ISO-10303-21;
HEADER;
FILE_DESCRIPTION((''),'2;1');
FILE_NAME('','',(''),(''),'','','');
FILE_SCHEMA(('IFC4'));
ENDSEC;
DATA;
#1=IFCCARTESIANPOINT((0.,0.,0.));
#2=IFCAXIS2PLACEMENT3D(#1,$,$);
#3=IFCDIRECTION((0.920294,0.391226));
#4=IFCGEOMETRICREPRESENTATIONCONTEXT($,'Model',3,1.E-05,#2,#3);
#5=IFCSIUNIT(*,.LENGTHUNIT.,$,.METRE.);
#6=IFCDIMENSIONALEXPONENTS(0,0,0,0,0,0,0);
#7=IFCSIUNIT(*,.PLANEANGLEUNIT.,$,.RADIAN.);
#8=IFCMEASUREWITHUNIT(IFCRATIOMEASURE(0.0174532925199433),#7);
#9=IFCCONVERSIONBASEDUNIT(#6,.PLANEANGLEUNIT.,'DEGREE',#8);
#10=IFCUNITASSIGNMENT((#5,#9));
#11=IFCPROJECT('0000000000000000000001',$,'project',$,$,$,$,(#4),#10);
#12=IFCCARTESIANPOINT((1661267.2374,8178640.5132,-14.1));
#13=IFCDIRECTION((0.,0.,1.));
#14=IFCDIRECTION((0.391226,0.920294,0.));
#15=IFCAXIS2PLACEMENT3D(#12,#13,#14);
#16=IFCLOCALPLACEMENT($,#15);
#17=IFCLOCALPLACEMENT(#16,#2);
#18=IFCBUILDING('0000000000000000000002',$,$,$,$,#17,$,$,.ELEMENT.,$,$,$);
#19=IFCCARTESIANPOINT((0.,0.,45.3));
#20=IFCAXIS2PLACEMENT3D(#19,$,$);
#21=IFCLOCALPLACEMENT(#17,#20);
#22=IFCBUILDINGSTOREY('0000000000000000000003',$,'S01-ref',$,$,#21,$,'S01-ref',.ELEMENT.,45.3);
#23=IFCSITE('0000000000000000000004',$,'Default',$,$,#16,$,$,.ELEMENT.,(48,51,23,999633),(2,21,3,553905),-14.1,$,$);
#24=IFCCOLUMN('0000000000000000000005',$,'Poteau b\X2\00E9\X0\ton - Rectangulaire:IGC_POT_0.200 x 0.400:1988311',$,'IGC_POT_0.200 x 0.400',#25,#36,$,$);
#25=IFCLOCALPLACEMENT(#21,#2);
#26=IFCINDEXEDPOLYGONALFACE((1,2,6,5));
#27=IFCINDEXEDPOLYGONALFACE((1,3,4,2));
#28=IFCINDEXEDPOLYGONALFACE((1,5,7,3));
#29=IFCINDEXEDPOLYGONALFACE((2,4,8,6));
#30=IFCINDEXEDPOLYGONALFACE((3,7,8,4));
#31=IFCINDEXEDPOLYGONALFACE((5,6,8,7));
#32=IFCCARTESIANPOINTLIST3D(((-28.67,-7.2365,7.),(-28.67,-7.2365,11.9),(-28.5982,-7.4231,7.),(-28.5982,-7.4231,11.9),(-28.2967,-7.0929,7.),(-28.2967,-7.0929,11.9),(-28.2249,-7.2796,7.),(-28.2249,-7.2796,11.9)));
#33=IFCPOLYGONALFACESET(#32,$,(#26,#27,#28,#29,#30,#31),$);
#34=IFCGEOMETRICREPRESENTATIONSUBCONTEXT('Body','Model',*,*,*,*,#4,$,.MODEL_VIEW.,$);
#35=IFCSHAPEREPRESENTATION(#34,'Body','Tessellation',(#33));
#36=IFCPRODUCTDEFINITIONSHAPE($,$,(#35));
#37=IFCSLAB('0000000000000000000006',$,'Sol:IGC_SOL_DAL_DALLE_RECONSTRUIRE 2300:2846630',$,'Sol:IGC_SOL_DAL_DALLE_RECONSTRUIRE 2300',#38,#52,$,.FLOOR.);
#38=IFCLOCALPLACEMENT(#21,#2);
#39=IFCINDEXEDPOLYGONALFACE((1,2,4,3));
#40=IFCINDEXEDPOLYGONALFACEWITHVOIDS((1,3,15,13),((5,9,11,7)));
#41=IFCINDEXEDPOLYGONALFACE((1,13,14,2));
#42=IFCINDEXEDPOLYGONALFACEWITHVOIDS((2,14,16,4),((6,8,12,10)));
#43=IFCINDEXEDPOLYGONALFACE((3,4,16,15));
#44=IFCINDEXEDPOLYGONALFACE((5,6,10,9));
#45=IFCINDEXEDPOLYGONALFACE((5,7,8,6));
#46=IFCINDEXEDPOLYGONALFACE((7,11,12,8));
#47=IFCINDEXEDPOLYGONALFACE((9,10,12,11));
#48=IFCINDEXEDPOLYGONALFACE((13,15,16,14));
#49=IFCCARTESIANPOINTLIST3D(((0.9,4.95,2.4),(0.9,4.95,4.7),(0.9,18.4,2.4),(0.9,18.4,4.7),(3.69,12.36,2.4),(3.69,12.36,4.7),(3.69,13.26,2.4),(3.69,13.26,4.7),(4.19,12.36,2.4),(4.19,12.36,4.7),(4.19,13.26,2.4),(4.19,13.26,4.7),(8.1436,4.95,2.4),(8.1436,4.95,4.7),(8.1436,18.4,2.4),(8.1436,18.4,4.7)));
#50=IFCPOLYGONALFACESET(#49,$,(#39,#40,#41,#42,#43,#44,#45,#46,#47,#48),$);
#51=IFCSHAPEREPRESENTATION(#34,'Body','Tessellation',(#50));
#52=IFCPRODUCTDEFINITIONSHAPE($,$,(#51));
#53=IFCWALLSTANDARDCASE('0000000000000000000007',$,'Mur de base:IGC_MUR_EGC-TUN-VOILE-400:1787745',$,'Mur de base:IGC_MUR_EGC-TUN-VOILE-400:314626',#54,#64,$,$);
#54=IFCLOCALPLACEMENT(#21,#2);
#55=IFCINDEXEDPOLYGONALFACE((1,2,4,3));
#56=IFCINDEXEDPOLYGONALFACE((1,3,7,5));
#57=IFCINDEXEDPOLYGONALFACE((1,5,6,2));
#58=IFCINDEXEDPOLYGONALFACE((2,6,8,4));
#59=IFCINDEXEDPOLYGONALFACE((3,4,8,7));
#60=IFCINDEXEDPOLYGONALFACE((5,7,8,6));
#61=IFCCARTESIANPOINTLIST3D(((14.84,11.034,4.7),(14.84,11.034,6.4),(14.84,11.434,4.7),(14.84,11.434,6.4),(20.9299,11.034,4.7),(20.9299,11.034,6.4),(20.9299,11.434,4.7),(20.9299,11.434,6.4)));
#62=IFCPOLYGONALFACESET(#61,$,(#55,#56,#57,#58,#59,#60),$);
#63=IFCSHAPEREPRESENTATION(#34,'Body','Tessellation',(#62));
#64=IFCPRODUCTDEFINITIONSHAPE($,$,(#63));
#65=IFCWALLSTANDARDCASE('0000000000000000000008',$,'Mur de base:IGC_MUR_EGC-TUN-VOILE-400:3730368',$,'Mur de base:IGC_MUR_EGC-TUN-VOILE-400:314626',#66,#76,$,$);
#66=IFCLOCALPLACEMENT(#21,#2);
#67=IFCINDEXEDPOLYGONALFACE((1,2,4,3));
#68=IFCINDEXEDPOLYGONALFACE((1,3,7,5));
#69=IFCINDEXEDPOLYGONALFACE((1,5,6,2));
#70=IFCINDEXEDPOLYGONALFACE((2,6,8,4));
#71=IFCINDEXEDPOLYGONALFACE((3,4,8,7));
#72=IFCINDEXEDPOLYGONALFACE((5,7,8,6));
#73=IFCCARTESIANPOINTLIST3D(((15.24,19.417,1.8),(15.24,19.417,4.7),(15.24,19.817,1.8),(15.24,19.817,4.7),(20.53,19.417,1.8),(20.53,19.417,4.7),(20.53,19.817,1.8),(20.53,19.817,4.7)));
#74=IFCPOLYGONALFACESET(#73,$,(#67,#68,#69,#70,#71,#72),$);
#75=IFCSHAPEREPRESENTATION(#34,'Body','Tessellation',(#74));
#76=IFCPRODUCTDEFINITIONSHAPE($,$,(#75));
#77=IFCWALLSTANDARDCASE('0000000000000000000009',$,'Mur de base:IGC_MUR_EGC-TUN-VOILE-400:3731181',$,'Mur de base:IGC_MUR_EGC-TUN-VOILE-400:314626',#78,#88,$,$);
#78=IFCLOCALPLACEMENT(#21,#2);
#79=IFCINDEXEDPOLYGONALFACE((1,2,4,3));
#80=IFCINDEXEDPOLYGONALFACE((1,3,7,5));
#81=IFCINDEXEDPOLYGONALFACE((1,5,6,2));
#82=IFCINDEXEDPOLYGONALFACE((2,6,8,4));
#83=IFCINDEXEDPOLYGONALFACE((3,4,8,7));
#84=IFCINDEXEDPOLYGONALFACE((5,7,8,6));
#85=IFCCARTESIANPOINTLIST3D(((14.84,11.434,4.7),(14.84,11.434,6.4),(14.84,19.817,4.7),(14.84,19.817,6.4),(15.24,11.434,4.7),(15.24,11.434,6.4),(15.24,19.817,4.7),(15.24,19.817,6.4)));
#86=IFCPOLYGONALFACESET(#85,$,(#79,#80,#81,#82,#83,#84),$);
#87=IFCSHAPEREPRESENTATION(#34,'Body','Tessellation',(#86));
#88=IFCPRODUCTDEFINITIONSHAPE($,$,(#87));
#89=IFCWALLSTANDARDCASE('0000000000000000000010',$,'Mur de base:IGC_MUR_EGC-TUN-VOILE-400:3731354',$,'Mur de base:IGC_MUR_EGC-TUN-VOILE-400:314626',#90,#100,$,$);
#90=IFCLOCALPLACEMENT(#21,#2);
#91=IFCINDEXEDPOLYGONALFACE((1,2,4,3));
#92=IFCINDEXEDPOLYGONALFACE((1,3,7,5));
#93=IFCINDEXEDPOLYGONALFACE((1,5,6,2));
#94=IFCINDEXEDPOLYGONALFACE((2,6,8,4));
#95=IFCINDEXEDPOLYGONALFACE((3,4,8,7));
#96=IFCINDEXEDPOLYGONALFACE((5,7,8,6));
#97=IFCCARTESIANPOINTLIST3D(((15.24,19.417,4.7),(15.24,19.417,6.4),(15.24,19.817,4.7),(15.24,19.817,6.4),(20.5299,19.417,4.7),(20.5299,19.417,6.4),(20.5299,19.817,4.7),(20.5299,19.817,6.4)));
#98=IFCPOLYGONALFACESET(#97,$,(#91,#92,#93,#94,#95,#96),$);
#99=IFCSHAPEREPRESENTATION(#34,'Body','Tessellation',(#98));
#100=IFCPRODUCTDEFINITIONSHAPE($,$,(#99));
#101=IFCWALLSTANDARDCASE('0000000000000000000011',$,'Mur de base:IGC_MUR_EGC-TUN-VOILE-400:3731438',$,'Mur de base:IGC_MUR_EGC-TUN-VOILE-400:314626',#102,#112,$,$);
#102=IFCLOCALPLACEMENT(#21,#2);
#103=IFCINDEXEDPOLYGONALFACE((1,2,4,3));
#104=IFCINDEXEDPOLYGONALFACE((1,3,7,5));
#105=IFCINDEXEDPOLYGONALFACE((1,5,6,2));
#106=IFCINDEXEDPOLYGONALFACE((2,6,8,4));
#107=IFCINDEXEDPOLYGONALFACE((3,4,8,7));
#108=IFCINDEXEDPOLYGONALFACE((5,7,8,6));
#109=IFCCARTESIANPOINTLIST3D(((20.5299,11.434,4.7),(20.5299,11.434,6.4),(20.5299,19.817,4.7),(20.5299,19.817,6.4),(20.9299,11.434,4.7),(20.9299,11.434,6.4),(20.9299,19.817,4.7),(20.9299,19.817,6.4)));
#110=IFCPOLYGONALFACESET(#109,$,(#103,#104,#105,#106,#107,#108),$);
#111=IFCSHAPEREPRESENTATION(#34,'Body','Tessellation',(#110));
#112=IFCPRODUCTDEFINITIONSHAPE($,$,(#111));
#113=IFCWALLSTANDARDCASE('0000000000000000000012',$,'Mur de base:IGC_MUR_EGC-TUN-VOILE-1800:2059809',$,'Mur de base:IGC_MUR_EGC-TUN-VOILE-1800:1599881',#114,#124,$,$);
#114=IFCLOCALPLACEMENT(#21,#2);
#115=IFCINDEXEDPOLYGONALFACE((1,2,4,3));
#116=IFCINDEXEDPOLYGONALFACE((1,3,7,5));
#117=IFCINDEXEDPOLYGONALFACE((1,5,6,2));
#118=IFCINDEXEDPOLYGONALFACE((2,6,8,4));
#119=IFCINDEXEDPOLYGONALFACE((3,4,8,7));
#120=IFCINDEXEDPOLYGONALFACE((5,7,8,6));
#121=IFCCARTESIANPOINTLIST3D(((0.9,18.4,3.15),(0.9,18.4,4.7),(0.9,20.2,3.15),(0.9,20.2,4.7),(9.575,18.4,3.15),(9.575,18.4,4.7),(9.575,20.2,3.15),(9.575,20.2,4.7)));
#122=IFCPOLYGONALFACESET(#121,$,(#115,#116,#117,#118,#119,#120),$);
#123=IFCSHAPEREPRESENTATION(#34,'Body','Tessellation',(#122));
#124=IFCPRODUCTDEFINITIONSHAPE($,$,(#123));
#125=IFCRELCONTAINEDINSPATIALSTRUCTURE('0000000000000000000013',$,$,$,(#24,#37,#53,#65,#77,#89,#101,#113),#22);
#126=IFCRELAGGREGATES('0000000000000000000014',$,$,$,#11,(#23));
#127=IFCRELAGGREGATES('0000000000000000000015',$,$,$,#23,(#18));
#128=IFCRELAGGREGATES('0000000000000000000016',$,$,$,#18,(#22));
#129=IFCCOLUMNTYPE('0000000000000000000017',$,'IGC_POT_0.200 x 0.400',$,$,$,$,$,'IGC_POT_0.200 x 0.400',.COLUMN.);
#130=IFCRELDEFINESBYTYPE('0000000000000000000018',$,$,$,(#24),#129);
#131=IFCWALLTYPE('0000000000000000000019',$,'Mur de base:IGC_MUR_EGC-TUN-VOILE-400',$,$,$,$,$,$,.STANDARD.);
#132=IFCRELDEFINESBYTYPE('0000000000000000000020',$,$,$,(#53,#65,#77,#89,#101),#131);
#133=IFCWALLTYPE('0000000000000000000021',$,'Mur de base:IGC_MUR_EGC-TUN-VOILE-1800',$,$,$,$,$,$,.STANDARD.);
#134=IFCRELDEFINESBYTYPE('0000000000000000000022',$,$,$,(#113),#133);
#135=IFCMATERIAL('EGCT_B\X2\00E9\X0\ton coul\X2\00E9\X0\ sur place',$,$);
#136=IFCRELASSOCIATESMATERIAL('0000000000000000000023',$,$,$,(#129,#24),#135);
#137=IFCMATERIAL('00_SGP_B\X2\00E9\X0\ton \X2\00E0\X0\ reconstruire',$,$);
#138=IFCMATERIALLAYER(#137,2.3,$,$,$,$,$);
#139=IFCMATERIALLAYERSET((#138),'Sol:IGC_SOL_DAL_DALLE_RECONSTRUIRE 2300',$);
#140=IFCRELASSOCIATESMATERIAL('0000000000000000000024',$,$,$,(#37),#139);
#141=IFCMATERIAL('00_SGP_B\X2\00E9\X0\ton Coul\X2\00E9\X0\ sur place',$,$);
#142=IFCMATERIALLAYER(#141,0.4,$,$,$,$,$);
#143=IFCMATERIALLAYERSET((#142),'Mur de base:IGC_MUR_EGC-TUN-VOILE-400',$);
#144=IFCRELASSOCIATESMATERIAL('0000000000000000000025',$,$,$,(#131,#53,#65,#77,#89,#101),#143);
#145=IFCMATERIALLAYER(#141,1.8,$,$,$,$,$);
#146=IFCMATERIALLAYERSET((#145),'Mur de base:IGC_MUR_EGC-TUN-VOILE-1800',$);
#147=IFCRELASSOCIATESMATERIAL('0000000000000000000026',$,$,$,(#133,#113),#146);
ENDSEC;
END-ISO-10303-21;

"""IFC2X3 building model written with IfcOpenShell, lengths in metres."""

from ifc_helpers import new_model, entity, si_unit, converted_unit, direction, frame, frame_2d, origin, origin_2d_with_axis, place, context, subcontext, project, spatial, rectangle, extrude, source, transform, mapped, material, layer, layer_set, layer_usage, type_object, type_shapes, element, save


model = new_model("IFC2X3")

# Units and contexts
model_context = context("Model", 3, precision=1e-05, world=origin(), true_north=direction((0.920294, 0.391226)))
body_context = subcontext(model_context, "Body", "Model", "MODEL_VIEW")
ifc_project = project(units=[si_unit("LENGTHUNIT", "METRE"), converted_unit("PLANEANGLEUNIT", "DEGREE", entity("IfcRatioMeasure", 0.0174532925199433), si_unit("PLANEANGLEUNIT", "RADIAN"), dimensions=[0, 0, 0, 0, 0, 0, 0])], contexts=[model_context])

# Site, building, storey
site_placement = place(None, frame((1661267.2374, 8178640.5132, -14.1), z_axis=(0.0, 0.0, 1.0), x_axis=(0.391226, 0.920294, 0.0)))
site = spatial("IfcSite", under=ifc_project, at=site_placement, Name="Default", CompositionType="ELEMENT", RefLatitude=(48, 51, 23, 999633), RefLongitude=(2, 21, 3, 553905), RefElevation=-14.1)
building_placement = place(site_placement, origin())
building = spatial("IfcBuilding", under=site, at=building_placement, CompositionType="ELEMENT")
storey_placement = place(building_placement, frame((0.0, 0.0, 45.3)))
storey = spatial("IfcBuildingStorey", under=building, at=storey_placement, Name="S01-ref", LongName="S01-ref", CompositionType="ELEMENT", Elevation=45.3)

# Column
ifc_material_1 = material(Name="EGCT_Béton coulé sur place")
column_type = type_object("IfcColumnType", Name="IGC_POT_0.200 x 0.400", ElementType="IGC_POT_0.200 x 0.400", PredefinedType="COLUMN", material=ifc_material_1)
shared_shape = source(origin(), body_context, "Body", "SweptSolid", [
    extrude(rectangle(XDim=0.2, YDim=0.4, at=frame_2d((0.0, 0.0), x_axis=(1.0, 0.0))), frame((-28.4474, -7.258, 52.3), z_axis=(0.0, 0.0, 1.0), x_axis=(-0.358954, 0.933355, 0.0)), (0.0, 0.0, 1.0), 4.9),
])
type_shapes(column_type, [shared_shape])
column_placement = place(storey_placement, frame((0.0, 0.0, -45.3)))
element("IfcColumn", 1, at=column_placement, inside=storey, type_object=column_type, material=ifc_material_1, Name="Poteau béton - Rectangulaire:IGC_POT_0.200 x 0.400:1988311", ObjectType="IGC_POT_0.200 x 0.400", context=body_context, shape_type="MappedRepresentation", body=[
    mapped(shared_shape, transform((0.0, 0.0, 0.0), scale=1.0)),
])

# Slab, opening
ifc_material_2 = material(Name="00_SGP_Béton à reconstruire")
ifc_layer_1 = layer(ifc_material_2, 2.3)
ifc_layer_set_1 = layer_set([ifc_layer_1], Name="Sol:IGC_SOL_DAL_DALLE_RECONSTRUIRE 2300")
ifc_layer_usage_1 = layer_usage(ifc_layer_set_1, "AXIS3", "POSITIVE", 0.0)
slab_placement = place(storey_placement, frame((0.9, 4.95, 2.4)))
slab = element("IfcSlab", 2, at=slab_placement, inside=storey, material=ifc_layer_usage_1, Name="Sol:IGC_SOL_DAL_DALLE_RECONSTRUIRE 2300:2846630", ObjectType="Sol:IGC_SOL_DAL_DALLE_RECONSTRUIRE 2300", PredefinedType="FLOOR", context=body_context, shape_type="SweptSolid", body=[
    extrude(rectangle(XDim=13.45, YDim=7.2436, at=frame_2d((0.0, 0.0), x_axis=(0.0, -1.0))), frame((3.6218, 6.725, 2.3), z_axis=(0.0, 0.0, -1.0), x_axis=(-1.0, 0.0, 0.0)), (0.0, 0.0, 1.0), 2.3),
])
opening_1_placement = place(slab_placement, origin())
element("IfcOpeningElement", 3, at=opening_1_placement, cuts=slab, ObjectType="Opening", context=body_context, shape_type="SweptSolid", body=[
    extrude(rectangle(XDim=0.5, YDim=0.9, at=origin_2d_with_axis()), frame((3.04, 7.86, 0.0), z_axis=(0.0, 0.0, 1.0), x_axis=(-1.0, 0.0, 0.0)), (0.0, 0.0, 1.0), 2.3),
])

# Shared definitions
ifc_material_3 = material(Name="00_SGP_Béton Coulé sur place")
ifc_layer_2 = layer(ifc_material_3, 0.4)
ifc_layer_set_2 = layer_set([ifc_layer_2], Name="Mur de base:IGC_MUR_EGC-TUN-VOILE-400")
wall_type_1 = type_object("IfcWallType", Name="Mur de base:IGC_MUR_EGC-TUN-VOILE-400", PredefinedType="STANDARD", material=ifc_layer_set_2)

# Walls
ifc_layer_usage_2 = layer_usage(ifc_layer_set_2, "AXIS2", "NEGATIVE", 0.2)
wall_1_placement = place(storey_placement, frame((20.9299, 11.234, 4.7), z_axis=(0.0, 0.0, 1.0), x_axis=(-1.0, 0.0, 0.0)))
element("IfcWallStandardCase", 4, at=wall_1_placement, inside=storey, type_object=wall_type_1, material=ifc_layer_usage_2, Name="Mur de base:IGC_MUR_EGC-TUN-VOILE-400:1787745", ObjectType="Mur de base:IGC_MUR_EGC-TUN-VOILE-400:314626", context=body_context, shape_type="SweptSolid", body=[
    extrude(rectangle(XDim=6.0899, YDim=0.4, at=frame_2d((3.045, 0.0), x_axis=(-1.0, 0.0))), origin(), (0.0, 0.0, 1.0), 1.7),
])
ifc_layer_usage_3 = layer_usage(ifc_layer_set_2, "AXIS2", "POSITIVE", -0.2)
wall_2_placement = place(storey_placement, frame((15.24, 19.617, 1.8)))
element("IfcWallStandardCase", 5, at=wall_2_placement, inside=storey, type_object=wall_type_1, material=ifc_layer_usage_3, Name="Mur de base:IGC_MUR_EGC-TUN-VOILE-400:3730368", ObjectType="Mur de base:IGC_MUR_EGC-TUN-VOILE-400:314626", context=body_context, shape_type="SweptSolid", body=[
    extrude(rectangle(XDim=5.29, YDim=0.4, at=frame_2d((2.645, 0.0), x_axis=(-1.0, 0.0))), origin(), (0.0, 0.0, 1.0), 2.9),
])
ifc_layer_usage_4 = layer_usage(ifc_layer_set_2, "AXIS2", "POSITIVE", -0.2)
wall_3_placement = place(storey_placement, frame((15.04, 11.434, 4.7), z_axis=(0.0, 0.0, 1.0), x_axis=(0.0, 1.0, 0.0)))
element("IfcWallStandardCase", 6, at=wall_3_placement, inside=storey, type_object=wall_type_1, material=ifc_layer_usage_4, Name="Mur de base:IGC_MUR_EGC-TUN-VOILE-400:3731181", ObjectType="Mur de base:IGC_MUR_EGC-TUN-VOILE-400:314626", context=body_context, shape_type="SweptSolid", body=[
    extrude(rectangle(XDim=8.383, YDim=0.4, at=frame_2d((4.1915, 0.0), x_axis=(-1.0, 0.0))), origin(), (0.0, 0.0, 1.0), 1.7),
])
ifc_layer_usage_5 = layer_usage(ifc_layer_set_2, "AXIS2", "POSITIVE", -0.2)
wall_4_placement = place(storey_placement, frame((15.24, 19.617, 4.7)))
element("IfcWallStandardCase", 7, at=wall_4_placement, inside=storey, type_object=wall_type_1, material=ifc_layer_usage_5, Name="Mur de base:IGC_MUR_EGC-TUN-VOILE-400:3731354", ObjectType="Mur de base:IGC_MUR_EGC-TUN-VOILE-400:314626", context=body_context, shape_type="SweptSolid", body=[
    extrude(rectangle(XDim=5.2899, YDim=0.4, at=frame_2d((2.645, 0.0), x_axis=(-1.0, 0.0))), origin(), (0.0, 0.0, 1.0), 1.7),
])
ifc_layer_usage_6 = layer_usage(ifc_layer_set_2, "AXIS2", "POSITIVE", -0.2)
wall_5_placement = place(storey_placement, frame((20.7299, 19.817, 4.7), z_axis=(0.0, 0.0, 1.0), x_axis=(0.0, -1.0, 0.0)))
element("IfcWallStandardCase", 8, at=wall_5_placement, inside=storey, type_object=wall_type_1, material=ifc_layer_usage_6, Name="Mur de base:IGC_MUR_EGC-TUN-VOILE-400:3731438", ObjectType="Mur de base:IGC_MUR_EGC-TUN-VOILE-400:314626", context=body_context, shape_type="SweptSolid", body=[
    extrude(rectangle(XDim=8.383, YDim=0.4, at=frame_2d((4.1915, 0.0), x_axis=(-1.0, 0.0))), origin(), (0.0, 0.0, 1.0), 1.7),
])

# Shared definitions
ifc_layer_3 = layer(ifc_material_3, 1.8)
ifc_layer_set_3 = layer_set([ifc_layer_3], Name="Mur de base:IGC_MUR_EGC-TUN-VOILE-1800")
wall_type_2 = type_object("IfcWallType", Name="Mur de base:IGC_MUR_EGC-TUN-VOILE-1800", PredefinedType="STANDARD", material=ifc_layer_set_3)

# Wall
ifc_layer_usage_7 = layer_usage(ifc_layer_set_3, "AXIS2", "NEGATIVE", 0.9)
wall_6_placement = place(storey_placement, frame((9.575, 19.3, 3.15), z_axis=(0.0, 0.0, 1.0), x_axis=(-1.0, 0.0, 0.0)))
element("IfcWallStandardCase", 9, at=wall_6_placement, inside=storey, type_object=wall_type_2, material=ifc_layer_usage_7, Name="Mur de base:IGC_MUR_EGC-TUN-VOILE-1800:2059809", ObjectType="Mur de base:IGC_MUR_EGC-TUN-VOILE-1800:1599881", context=body_context, shape_type="SweptSolid", body=[
    extrude(rectangle(XDim=8.675, YDim=1.8, at=frame_2d((4.3375, 0.0), x_axis=(-1.0, 0.0))), origin(), (0.0, 0.0, 1.0), 1.55),
])

save(model, "model.ifc")
